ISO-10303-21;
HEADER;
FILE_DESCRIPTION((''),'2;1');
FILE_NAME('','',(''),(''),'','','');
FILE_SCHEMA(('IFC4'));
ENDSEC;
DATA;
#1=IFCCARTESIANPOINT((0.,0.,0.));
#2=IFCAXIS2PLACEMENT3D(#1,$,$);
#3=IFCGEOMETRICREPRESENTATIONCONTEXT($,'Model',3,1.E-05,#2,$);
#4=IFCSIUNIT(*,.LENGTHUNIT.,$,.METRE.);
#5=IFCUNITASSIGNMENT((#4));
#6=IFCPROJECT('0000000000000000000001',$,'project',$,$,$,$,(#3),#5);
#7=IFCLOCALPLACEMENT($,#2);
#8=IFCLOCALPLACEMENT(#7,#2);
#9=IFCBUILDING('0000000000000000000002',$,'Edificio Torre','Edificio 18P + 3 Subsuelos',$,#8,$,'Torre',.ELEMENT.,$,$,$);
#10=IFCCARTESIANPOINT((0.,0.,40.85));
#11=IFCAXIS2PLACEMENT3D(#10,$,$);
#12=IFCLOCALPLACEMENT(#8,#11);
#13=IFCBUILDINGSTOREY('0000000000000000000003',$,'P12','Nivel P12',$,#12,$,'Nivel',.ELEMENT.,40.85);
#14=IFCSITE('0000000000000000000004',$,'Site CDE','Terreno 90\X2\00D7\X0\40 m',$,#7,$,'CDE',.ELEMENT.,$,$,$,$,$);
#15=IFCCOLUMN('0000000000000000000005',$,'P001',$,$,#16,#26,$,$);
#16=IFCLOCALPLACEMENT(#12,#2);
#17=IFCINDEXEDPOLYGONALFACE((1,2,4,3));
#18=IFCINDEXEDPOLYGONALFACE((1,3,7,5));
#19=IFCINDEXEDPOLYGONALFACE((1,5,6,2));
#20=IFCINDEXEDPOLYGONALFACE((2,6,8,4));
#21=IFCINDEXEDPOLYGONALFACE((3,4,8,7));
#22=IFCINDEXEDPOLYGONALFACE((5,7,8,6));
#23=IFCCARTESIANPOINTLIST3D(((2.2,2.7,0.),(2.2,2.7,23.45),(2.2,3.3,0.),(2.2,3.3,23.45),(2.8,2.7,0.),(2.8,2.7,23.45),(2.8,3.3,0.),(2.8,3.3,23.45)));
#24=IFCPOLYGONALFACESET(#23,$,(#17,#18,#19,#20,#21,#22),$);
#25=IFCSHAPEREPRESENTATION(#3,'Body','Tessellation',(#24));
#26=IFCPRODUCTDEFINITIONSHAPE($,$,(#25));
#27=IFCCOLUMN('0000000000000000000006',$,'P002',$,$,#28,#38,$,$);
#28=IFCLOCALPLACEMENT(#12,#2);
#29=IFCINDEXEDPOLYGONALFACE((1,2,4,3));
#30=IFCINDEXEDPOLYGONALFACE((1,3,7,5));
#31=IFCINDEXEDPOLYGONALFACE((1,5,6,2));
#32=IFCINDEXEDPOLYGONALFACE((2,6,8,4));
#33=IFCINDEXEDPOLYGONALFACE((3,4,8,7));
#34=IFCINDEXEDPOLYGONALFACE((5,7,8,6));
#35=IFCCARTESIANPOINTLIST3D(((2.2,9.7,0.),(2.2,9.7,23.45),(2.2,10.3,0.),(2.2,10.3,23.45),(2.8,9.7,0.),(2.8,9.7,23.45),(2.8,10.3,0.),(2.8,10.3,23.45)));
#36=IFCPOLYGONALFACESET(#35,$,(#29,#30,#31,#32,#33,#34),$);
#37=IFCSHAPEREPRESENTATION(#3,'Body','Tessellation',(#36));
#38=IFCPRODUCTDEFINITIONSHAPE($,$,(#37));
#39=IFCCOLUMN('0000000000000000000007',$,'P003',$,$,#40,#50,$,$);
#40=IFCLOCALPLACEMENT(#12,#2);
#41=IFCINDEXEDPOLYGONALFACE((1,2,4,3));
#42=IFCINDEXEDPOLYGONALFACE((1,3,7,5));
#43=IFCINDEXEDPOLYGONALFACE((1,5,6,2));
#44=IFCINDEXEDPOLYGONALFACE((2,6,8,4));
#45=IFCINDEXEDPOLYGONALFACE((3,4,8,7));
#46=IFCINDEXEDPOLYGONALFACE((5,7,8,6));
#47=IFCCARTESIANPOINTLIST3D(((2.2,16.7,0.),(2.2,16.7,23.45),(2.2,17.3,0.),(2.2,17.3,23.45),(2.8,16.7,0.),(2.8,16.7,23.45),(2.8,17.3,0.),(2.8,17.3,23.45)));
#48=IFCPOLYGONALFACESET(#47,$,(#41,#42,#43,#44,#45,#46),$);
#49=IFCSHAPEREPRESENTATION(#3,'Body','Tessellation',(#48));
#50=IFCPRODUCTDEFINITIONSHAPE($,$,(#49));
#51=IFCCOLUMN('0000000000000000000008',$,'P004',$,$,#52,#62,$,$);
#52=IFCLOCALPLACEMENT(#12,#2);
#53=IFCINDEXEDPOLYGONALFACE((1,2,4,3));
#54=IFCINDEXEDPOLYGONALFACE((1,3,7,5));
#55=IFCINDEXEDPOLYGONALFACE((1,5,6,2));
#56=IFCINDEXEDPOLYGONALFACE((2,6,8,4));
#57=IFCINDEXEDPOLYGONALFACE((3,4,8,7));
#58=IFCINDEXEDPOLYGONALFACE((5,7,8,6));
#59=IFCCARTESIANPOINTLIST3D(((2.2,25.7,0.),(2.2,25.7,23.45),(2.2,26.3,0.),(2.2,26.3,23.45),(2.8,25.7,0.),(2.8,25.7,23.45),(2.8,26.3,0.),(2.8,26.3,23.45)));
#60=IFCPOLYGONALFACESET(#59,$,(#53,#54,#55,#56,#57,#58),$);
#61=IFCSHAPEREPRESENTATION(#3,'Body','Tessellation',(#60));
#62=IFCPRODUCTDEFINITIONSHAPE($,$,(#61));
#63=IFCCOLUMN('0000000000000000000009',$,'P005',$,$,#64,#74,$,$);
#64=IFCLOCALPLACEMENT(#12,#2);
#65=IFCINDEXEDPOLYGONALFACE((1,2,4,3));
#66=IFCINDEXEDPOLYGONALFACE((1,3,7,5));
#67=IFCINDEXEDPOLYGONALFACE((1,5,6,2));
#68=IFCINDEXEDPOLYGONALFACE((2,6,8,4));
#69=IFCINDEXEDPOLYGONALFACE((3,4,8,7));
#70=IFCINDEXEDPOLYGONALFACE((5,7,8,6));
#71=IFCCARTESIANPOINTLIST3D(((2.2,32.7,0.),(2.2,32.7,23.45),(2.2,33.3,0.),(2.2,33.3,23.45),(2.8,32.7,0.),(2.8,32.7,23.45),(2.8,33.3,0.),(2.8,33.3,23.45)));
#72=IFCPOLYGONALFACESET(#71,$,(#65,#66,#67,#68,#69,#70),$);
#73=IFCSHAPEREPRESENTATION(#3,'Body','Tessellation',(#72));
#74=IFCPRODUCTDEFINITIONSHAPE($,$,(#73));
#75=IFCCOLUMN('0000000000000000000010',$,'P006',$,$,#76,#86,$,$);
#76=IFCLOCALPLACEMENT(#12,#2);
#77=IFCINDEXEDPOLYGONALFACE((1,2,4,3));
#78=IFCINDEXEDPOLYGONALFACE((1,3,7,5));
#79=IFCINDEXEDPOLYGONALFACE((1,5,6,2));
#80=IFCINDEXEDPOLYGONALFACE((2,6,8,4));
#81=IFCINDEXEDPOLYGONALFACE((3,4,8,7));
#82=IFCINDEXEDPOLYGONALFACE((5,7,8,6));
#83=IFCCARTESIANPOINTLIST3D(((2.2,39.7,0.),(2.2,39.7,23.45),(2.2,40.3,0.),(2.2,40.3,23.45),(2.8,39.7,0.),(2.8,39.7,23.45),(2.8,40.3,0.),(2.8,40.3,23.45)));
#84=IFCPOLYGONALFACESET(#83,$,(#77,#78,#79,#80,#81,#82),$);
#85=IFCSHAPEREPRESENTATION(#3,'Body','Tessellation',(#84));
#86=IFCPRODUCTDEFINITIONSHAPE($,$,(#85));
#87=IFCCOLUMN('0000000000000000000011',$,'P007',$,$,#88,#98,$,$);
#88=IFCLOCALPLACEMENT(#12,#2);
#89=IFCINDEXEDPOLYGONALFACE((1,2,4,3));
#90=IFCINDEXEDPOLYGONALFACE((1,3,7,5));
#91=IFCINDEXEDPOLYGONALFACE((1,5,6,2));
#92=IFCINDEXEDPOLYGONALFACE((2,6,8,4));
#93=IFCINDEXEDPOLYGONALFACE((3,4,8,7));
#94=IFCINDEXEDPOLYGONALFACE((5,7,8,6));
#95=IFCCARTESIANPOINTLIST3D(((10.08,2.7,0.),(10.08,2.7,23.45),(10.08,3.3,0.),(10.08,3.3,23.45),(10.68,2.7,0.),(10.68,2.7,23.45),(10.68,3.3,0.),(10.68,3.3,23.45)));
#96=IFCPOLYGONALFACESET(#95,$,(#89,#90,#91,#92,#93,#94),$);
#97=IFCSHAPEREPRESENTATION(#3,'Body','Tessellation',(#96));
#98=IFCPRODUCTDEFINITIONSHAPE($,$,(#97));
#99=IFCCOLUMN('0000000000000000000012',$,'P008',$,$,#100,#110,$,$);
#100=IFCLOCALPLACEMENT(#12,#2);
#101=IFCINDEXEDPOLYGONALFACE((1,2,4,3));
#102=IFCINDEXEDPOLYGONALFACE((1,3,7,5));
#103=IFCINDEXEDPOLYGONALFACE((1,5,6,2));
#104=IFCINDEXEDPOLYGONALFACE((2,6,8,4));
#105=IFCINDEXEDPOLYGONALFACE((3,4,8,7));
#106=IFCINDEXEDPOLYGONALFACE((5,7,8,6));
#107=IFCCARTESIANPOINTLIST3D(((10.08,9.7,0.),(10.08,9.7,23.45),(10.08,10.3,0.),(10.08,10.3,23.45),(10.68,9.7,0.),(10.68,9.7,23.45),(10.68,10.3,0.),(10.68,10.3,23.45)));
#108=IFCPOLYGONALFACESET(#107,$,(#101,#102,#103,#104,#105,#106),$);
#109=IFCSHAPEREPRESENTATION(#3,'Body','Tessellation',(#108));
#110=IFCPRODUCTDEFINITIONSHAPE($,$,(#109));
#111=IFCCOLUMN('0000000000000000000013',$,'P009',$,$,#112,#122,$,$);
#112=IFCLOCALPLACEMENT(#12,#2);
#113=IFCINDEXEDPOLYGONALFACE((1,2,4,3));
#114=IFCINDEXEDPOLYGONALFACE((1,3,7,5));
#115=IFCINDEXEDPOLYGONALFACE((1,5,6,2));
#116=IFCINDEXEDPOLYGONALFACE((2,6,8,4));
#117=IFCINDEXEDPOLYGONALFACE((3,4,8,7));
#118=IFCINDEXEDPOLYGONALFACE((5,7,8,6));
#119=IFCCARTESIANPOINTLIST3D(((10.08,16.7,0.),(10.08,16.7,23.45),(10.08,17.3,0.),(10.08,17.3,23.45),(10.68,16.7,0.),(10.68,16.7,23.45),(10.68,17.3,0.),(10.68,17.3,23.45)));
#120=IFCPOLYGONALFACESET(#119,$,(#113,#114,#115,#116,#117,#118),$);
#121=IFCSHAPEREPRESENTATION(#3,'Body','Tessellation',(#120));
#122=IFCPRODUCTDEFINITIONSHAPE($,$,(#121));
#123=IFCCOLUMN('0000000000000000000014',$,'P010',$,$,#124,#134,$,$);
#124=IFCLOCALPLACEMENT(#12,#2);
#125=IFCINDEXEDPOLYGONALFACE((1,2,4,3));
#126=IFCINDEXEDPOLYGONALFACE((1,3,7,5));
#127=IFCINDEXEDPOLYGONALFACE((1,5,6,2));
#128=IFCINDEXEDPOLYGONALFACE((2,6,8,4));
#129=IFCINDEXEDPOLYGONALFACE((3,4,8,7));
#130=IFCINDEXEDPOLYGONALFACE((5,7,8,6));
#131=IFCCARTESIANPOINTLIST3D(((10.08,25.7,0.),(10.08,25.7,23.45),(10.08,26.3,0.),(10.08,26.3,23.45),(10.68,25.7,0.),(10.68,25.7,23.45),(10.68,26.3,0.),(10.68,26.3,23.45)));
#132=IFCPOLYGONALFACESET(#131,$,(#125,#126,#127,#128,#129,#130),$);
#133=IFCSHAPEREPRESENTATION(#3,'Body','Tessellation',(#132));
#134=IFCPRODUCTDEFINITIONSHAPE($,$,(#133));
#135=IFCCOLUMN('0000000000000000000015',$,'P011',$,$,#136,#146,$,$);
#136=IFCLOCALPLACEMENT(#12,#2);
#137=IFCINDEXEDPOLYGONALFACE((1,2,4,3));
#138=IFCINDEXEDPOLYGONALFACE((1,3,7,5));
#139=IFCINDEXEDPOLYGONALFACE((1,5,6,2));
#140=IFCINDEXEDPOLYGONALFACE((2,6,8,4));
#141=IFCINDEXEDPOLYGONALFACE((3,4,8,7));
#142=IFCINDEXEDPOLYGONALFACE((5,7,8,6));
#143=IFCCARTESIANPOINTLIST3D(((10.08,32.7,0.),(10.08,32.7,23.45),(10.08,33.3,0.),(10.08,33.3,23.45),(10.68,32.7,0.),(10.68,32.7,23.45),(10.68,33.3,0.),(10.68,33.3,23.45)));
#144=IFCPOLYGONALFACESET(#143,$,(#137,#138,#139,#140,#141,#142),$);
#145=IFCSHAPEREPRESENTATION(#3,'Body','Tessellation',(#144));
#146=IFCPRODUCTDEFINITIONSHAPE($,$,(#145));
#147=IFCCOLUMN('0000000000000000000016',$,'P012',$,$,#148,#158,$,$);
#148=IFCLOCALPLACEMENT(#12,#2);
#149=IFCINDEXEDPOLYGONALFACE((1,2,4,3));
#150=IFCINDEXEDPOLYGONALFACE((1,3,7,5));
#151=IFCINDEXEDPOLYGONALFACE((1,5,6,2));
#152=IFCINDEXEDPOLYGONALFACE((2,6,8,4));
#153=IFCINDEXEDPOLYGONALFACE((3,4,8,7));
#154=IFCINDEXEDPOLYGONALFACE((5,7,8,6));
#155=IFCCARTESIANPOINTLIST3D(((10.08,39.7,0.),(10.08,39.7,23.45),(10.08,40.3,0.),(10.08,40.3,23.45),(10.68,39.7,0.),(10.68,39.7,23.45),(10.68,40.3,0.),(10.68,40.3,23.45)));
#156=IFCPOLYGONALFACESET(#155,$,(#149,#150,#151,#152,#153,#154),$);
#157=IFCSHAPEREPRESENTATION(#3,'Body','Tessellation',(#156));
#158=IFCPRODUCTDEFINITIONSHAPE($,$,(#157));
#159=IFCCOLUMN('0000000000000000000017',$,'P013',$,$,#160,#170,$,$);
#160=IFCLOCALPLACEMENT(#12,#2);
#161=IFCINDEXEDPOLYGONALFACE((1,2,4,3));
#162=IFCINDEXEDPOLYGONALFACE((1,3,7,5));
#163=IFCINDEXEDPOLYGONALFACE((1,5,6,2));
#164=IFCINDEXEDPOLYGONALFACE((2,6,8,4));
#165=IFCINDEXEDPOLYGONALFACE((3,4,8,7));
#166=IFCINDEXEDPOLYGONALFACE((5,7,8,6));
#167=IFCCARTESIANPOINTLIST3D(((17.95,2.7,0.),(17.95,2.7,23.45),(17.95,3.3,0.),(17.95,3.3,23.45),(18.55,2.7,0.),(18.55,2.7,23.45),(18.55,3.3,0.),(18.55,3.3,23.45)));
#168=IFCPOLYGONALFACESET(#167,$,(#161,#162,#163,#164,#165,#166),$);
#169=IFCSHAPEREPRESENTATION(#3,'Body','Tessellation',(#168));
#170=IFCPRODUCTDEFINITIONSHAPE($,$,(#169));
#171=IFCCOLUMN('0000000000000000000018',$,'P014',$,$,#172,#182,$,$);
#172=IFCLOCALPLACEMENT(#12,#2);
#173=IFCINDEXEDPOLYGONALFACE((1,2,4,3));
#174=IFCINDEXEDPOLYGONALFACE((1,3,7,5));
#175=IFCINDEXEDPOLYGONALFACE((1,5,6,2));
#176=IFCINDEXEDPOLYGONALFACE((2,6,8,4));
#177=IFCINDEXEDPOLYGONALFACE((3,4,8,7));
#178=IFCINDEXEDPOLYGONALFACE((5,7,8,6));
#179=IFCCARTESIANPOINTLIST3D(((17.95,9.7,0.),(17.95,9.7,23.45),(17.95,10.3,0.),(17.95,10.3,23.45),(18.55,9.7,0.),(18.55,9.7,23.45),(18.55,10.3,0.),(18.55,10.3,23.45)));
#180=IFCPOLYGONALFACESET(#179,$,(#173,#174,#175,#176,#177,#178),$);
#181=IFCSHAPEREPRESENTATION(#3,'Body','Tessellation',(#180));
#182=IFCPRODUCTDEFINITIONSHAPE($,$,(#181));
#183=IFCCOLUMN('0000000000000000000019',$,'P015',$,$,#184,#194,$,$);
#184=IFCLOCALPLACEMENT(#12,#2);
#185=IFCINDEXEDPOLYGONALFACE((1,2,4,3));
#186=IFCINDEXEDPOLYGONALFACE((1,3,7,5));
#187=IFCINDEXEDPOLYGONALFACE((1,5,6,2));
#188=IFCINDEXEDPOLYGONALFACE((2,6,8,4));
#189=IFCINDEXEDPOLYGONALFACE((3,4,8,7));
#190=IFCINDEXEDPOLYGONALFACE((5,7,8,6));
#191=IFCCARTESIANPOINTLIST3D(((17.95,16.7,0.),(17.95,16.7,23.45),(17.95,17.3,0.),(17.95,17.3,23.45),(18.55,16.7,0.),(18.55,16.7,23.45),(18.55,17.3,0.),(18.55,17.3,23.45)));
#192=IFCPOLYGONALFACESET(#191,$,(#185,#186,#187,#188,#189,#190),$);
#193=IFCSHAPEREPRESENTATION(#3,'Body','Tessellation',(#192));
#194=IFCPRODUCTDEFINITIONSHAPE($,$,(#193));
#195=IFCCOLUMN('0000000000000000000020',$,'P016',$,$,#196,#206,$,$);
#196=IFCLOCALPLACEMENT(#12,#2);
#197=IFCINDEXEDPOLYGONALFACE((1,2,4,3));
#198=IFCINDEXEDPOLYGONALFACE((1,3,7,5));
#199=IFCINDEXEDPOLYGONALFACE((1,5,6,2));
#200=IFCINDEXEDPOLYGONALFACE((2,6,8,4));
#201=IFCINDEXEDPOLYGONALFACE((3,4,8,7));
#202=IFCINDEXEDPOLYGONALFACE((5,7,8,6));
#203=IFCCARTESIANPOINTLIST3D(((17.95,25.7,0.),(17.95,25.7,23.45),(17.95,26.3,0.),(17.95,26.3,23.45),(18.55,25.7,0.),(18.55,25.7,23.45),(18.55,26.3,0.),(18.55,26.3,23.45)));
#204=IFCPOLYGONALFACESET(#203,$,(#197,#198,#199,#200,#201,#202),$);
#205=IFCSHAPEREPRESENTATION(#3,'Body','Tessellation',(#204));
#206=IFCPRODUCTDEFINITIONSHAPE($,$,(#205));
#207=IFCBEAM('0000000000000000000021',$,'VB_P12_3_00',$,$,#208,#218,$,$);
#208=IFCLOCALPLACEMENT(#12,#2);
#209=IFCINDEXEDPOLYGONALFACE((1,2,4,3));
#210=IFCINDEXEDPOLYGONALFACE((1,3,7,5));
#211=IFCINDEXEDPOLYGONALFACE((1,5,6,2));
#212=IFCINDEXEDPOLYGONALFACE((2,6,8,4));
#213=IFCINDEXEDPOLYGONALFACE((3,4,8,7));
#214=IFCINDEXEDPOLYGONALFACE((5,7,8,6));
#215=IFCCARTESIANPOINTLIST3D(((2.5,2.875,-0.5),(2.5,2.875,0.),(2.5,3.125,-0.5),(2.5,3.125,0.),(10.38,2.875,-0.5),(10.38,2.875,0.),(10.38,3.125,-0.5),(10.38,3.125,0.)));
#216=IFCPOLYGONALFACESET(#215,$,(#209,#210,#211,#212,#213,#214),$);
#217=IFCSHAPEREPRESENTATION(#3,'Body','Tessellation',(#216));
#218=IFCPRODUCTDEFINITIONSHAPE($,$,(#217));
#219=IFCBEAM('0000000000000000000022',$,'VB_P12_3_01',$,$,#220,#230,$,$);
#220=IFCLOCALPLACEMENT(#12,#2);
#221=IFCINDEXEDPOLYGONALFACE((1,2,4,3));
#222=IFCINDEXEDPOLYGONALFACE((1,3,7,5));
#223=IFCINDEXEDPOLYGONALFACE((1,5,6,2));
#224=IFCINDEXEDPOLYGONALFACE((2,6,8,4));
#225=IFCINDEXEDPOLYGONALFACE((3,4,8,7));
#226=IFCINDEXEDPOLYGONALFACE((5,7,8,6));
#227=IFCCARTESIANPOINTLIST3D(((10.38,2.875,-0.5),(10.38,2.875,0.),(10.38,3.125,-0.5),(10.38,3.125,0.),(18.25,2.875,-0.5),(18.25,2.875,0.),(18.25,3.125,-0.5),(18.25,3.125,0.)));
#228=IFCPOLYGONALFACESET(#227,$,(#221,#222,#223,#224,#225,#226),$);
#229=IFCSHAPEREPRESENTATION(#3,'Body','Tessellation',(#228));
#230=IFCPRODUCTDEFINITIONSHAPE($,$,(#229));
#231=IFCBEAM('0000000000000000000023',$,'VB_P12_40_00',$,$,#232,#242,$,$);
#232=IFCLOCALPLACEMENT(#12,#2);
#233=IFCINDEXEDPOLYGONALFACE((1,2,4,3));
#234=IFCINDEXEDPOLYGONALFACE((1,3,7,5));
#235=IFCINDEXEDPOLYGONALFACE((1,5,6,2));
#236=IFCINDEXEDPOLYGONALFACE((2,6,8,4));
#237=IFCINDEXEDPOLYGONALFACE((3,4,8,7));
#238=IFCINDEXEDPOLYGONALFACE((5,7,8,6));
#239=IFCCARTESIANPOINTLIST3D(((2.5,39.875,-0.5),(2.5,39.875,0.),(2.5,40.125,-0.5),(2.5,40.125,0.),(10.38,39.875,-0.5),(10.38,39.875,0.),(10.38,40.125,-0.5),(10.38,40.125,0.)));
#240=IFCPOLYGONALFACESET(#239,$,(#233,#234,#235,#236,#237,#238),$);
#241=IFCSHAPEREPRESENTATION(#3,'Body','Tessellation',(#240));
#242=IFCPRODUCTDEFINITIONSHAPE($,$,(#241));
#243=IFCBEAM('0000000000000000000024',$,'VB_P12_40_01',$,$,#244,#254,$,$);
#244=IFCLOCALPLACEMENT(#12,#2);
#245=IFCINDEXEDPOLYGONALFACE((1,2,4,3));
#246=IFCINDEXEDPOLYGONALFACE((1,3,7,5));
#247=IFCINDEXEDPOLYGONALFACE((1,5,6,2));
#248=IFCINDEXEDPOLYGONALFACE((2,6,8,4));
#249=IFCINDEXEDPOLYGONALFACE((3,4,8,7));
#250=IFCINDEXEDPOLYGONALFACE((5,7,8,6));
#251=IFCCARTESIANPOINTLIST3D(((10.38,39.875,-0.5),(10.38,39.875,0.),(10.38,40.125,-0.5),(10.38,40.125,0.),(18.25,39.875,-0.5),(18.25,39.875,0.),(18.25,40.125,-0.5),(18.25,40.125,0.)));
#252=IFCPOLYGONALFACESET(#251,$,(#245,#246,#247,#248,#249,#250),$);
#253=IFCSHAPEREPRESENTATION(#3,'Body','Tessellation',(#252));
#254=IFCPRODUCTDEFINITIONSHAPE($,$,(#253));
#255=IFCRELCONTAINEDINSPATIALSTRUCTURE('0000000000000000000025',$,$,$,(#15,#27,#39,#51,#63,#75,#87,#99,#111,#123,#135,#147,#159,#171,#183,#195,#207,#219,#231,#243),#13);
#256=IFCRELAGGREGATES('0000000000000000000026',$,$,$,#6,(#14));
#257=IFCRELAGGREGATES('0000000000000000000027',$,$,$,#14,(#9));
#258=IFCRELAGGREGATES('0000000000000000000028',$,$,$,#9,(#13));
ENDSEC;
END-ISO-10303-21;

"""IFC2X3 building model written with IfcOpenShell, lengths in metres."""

from ifc_helpers import new_model, si_unit, frame, origin, origin_2d, place, context, project, spatial, rectangle, extrude, element, save


model = new_model("IFC2X3")

# Units and contexts
model_context = context("Model", 3, precision=1e-05, world=origin())
ifc_project = project(units=[si_unit("LENGTHUNIT", "METRE")], contexts=[model_context])

# Site, building, storey
site_placement = place(None, origin())
site = spatial("IfcSite", under=ifc_project, at=site_placement, Name="Site CDE", Description="Terreno 90×40 m", LongName="CDE", CompositionType="ELEMENT")
building_placement = place(site_placement, origin())
building = spatial("IfcBuilding", under=site, at=building_placement, Name="Edificio Torre", Description="Edificio 18P + 3 Subsuelos", LongName="Torre", CompositionType="ELEMENT")
storey_placement = place(building_placement, frame((0.0, 0.0, 40.85)))
storey = spatial("IfcBuildingStorey", under=building, at=storey_placement, Name="P12", Description="Nivel P12", LongName="Nivel", CompositionType="ELEMENT", Elevation=40.85)

# Columns
for number, where, name in (
    (1, (2.5, 3.0, 0.0), "P001"),
    (2, (2.5, 10.0, 0.0), "P002"),
    (3, (2.5, 17.0, 0.0), "P003"),
    (4, (2.5, 26.0, 0.0), "P004"),
    (5, (2.5, 33.0, 0.0), "P005"),
    (6, (2.5, 40.0, 0.0), "P006"),
    (7, (10.38, 3.0, 0.0), "P007"),
    (8, (10.38, 10.0, 0.0), "P008"),
    (9, (10.38, 17.0, 0.0), "P009"),
    (10, (10.38, 26.0, 0.0), "P010"),
    (11, (10.38, 33.0, 0.0), "P011"),
    (12, (10.38, 40.0, 0.0), "P012"),
    (13, (18.25, 3.0, 0.0), "P013"),
    (14, (18.25, 10.0, 0.0), "P014"),
    (15, (18.25, 17.0, 0.0), "P015"),
    (16, (18.25, 26.0, 0.0), "P016"),
):
    element("IfcColumn", number, at=place(storey_placement, frame(where)), inside=storey, Name=name, context=model_context, shape_type="SweptSolid", body=[
        extrude(rectangle(XDim=0.6, YDim=0.6, at=origin_2d()), origin(), (0.0, 0.0, 1.0), 23.45),
    ])

# Beams
beam_1_placement = place(storey_placement, frame((6.44, 3.0, -0.5)))
element("IfcBeam", 17, at=beam_1_placement, inside=storey, Name="VB_P12_3_00", context=model_context, shape_type="SweptSolid", body=[
    extrude(rectangle(XDim=7.88, YDim=0.25, at=origin_2d()), origin(), (0.0, 0.0, 1.0), 0.5),
])
beam_2_placement = place(storey_placement, frame((14.315, 3.0, -0.5)))
element("IfcBeam", 18, at=beam_2_placement, inside=storey, Name="VB_P12_3_01", context=model_context, shape_type="SweptSolid", body=[
    extrude(rectangle(XDim=7.87, YDim=0.25, at=origin_2d()), origin(), (0.0, 0.0, 1.0), 0.5),
])
beam_3_placement = place(storey_placement, frame((6.44, 40.0, -0.5)))
element("IfcBeam", 19, at=beam_3_placement, inside=storey, Name="VB_P12_40_00", context=model_context, shape_type="SweptSolid", body=[
    extrude(rectangle(XDim=7.88, YDim=0.25, at=origin_2d()), origin(), (0.0, 0.0, 1.0), 0.5),
])
beam_4_placement = place(storey_placement, frame((14.315, 40.0, -0.5)))
element("IfcBeam", 20, at=beam_4_placement, inside=storey, Name="VB_P12_40_01", context=model_context, shape_type="SweptSolid", body=[
    extrude(rectangle(XDim=7.87, YDim=0.25, at=origin_2d()), origin(), (0.0, 0.0, 1.0), 0.5),
])

save(model, "model.ifc")
